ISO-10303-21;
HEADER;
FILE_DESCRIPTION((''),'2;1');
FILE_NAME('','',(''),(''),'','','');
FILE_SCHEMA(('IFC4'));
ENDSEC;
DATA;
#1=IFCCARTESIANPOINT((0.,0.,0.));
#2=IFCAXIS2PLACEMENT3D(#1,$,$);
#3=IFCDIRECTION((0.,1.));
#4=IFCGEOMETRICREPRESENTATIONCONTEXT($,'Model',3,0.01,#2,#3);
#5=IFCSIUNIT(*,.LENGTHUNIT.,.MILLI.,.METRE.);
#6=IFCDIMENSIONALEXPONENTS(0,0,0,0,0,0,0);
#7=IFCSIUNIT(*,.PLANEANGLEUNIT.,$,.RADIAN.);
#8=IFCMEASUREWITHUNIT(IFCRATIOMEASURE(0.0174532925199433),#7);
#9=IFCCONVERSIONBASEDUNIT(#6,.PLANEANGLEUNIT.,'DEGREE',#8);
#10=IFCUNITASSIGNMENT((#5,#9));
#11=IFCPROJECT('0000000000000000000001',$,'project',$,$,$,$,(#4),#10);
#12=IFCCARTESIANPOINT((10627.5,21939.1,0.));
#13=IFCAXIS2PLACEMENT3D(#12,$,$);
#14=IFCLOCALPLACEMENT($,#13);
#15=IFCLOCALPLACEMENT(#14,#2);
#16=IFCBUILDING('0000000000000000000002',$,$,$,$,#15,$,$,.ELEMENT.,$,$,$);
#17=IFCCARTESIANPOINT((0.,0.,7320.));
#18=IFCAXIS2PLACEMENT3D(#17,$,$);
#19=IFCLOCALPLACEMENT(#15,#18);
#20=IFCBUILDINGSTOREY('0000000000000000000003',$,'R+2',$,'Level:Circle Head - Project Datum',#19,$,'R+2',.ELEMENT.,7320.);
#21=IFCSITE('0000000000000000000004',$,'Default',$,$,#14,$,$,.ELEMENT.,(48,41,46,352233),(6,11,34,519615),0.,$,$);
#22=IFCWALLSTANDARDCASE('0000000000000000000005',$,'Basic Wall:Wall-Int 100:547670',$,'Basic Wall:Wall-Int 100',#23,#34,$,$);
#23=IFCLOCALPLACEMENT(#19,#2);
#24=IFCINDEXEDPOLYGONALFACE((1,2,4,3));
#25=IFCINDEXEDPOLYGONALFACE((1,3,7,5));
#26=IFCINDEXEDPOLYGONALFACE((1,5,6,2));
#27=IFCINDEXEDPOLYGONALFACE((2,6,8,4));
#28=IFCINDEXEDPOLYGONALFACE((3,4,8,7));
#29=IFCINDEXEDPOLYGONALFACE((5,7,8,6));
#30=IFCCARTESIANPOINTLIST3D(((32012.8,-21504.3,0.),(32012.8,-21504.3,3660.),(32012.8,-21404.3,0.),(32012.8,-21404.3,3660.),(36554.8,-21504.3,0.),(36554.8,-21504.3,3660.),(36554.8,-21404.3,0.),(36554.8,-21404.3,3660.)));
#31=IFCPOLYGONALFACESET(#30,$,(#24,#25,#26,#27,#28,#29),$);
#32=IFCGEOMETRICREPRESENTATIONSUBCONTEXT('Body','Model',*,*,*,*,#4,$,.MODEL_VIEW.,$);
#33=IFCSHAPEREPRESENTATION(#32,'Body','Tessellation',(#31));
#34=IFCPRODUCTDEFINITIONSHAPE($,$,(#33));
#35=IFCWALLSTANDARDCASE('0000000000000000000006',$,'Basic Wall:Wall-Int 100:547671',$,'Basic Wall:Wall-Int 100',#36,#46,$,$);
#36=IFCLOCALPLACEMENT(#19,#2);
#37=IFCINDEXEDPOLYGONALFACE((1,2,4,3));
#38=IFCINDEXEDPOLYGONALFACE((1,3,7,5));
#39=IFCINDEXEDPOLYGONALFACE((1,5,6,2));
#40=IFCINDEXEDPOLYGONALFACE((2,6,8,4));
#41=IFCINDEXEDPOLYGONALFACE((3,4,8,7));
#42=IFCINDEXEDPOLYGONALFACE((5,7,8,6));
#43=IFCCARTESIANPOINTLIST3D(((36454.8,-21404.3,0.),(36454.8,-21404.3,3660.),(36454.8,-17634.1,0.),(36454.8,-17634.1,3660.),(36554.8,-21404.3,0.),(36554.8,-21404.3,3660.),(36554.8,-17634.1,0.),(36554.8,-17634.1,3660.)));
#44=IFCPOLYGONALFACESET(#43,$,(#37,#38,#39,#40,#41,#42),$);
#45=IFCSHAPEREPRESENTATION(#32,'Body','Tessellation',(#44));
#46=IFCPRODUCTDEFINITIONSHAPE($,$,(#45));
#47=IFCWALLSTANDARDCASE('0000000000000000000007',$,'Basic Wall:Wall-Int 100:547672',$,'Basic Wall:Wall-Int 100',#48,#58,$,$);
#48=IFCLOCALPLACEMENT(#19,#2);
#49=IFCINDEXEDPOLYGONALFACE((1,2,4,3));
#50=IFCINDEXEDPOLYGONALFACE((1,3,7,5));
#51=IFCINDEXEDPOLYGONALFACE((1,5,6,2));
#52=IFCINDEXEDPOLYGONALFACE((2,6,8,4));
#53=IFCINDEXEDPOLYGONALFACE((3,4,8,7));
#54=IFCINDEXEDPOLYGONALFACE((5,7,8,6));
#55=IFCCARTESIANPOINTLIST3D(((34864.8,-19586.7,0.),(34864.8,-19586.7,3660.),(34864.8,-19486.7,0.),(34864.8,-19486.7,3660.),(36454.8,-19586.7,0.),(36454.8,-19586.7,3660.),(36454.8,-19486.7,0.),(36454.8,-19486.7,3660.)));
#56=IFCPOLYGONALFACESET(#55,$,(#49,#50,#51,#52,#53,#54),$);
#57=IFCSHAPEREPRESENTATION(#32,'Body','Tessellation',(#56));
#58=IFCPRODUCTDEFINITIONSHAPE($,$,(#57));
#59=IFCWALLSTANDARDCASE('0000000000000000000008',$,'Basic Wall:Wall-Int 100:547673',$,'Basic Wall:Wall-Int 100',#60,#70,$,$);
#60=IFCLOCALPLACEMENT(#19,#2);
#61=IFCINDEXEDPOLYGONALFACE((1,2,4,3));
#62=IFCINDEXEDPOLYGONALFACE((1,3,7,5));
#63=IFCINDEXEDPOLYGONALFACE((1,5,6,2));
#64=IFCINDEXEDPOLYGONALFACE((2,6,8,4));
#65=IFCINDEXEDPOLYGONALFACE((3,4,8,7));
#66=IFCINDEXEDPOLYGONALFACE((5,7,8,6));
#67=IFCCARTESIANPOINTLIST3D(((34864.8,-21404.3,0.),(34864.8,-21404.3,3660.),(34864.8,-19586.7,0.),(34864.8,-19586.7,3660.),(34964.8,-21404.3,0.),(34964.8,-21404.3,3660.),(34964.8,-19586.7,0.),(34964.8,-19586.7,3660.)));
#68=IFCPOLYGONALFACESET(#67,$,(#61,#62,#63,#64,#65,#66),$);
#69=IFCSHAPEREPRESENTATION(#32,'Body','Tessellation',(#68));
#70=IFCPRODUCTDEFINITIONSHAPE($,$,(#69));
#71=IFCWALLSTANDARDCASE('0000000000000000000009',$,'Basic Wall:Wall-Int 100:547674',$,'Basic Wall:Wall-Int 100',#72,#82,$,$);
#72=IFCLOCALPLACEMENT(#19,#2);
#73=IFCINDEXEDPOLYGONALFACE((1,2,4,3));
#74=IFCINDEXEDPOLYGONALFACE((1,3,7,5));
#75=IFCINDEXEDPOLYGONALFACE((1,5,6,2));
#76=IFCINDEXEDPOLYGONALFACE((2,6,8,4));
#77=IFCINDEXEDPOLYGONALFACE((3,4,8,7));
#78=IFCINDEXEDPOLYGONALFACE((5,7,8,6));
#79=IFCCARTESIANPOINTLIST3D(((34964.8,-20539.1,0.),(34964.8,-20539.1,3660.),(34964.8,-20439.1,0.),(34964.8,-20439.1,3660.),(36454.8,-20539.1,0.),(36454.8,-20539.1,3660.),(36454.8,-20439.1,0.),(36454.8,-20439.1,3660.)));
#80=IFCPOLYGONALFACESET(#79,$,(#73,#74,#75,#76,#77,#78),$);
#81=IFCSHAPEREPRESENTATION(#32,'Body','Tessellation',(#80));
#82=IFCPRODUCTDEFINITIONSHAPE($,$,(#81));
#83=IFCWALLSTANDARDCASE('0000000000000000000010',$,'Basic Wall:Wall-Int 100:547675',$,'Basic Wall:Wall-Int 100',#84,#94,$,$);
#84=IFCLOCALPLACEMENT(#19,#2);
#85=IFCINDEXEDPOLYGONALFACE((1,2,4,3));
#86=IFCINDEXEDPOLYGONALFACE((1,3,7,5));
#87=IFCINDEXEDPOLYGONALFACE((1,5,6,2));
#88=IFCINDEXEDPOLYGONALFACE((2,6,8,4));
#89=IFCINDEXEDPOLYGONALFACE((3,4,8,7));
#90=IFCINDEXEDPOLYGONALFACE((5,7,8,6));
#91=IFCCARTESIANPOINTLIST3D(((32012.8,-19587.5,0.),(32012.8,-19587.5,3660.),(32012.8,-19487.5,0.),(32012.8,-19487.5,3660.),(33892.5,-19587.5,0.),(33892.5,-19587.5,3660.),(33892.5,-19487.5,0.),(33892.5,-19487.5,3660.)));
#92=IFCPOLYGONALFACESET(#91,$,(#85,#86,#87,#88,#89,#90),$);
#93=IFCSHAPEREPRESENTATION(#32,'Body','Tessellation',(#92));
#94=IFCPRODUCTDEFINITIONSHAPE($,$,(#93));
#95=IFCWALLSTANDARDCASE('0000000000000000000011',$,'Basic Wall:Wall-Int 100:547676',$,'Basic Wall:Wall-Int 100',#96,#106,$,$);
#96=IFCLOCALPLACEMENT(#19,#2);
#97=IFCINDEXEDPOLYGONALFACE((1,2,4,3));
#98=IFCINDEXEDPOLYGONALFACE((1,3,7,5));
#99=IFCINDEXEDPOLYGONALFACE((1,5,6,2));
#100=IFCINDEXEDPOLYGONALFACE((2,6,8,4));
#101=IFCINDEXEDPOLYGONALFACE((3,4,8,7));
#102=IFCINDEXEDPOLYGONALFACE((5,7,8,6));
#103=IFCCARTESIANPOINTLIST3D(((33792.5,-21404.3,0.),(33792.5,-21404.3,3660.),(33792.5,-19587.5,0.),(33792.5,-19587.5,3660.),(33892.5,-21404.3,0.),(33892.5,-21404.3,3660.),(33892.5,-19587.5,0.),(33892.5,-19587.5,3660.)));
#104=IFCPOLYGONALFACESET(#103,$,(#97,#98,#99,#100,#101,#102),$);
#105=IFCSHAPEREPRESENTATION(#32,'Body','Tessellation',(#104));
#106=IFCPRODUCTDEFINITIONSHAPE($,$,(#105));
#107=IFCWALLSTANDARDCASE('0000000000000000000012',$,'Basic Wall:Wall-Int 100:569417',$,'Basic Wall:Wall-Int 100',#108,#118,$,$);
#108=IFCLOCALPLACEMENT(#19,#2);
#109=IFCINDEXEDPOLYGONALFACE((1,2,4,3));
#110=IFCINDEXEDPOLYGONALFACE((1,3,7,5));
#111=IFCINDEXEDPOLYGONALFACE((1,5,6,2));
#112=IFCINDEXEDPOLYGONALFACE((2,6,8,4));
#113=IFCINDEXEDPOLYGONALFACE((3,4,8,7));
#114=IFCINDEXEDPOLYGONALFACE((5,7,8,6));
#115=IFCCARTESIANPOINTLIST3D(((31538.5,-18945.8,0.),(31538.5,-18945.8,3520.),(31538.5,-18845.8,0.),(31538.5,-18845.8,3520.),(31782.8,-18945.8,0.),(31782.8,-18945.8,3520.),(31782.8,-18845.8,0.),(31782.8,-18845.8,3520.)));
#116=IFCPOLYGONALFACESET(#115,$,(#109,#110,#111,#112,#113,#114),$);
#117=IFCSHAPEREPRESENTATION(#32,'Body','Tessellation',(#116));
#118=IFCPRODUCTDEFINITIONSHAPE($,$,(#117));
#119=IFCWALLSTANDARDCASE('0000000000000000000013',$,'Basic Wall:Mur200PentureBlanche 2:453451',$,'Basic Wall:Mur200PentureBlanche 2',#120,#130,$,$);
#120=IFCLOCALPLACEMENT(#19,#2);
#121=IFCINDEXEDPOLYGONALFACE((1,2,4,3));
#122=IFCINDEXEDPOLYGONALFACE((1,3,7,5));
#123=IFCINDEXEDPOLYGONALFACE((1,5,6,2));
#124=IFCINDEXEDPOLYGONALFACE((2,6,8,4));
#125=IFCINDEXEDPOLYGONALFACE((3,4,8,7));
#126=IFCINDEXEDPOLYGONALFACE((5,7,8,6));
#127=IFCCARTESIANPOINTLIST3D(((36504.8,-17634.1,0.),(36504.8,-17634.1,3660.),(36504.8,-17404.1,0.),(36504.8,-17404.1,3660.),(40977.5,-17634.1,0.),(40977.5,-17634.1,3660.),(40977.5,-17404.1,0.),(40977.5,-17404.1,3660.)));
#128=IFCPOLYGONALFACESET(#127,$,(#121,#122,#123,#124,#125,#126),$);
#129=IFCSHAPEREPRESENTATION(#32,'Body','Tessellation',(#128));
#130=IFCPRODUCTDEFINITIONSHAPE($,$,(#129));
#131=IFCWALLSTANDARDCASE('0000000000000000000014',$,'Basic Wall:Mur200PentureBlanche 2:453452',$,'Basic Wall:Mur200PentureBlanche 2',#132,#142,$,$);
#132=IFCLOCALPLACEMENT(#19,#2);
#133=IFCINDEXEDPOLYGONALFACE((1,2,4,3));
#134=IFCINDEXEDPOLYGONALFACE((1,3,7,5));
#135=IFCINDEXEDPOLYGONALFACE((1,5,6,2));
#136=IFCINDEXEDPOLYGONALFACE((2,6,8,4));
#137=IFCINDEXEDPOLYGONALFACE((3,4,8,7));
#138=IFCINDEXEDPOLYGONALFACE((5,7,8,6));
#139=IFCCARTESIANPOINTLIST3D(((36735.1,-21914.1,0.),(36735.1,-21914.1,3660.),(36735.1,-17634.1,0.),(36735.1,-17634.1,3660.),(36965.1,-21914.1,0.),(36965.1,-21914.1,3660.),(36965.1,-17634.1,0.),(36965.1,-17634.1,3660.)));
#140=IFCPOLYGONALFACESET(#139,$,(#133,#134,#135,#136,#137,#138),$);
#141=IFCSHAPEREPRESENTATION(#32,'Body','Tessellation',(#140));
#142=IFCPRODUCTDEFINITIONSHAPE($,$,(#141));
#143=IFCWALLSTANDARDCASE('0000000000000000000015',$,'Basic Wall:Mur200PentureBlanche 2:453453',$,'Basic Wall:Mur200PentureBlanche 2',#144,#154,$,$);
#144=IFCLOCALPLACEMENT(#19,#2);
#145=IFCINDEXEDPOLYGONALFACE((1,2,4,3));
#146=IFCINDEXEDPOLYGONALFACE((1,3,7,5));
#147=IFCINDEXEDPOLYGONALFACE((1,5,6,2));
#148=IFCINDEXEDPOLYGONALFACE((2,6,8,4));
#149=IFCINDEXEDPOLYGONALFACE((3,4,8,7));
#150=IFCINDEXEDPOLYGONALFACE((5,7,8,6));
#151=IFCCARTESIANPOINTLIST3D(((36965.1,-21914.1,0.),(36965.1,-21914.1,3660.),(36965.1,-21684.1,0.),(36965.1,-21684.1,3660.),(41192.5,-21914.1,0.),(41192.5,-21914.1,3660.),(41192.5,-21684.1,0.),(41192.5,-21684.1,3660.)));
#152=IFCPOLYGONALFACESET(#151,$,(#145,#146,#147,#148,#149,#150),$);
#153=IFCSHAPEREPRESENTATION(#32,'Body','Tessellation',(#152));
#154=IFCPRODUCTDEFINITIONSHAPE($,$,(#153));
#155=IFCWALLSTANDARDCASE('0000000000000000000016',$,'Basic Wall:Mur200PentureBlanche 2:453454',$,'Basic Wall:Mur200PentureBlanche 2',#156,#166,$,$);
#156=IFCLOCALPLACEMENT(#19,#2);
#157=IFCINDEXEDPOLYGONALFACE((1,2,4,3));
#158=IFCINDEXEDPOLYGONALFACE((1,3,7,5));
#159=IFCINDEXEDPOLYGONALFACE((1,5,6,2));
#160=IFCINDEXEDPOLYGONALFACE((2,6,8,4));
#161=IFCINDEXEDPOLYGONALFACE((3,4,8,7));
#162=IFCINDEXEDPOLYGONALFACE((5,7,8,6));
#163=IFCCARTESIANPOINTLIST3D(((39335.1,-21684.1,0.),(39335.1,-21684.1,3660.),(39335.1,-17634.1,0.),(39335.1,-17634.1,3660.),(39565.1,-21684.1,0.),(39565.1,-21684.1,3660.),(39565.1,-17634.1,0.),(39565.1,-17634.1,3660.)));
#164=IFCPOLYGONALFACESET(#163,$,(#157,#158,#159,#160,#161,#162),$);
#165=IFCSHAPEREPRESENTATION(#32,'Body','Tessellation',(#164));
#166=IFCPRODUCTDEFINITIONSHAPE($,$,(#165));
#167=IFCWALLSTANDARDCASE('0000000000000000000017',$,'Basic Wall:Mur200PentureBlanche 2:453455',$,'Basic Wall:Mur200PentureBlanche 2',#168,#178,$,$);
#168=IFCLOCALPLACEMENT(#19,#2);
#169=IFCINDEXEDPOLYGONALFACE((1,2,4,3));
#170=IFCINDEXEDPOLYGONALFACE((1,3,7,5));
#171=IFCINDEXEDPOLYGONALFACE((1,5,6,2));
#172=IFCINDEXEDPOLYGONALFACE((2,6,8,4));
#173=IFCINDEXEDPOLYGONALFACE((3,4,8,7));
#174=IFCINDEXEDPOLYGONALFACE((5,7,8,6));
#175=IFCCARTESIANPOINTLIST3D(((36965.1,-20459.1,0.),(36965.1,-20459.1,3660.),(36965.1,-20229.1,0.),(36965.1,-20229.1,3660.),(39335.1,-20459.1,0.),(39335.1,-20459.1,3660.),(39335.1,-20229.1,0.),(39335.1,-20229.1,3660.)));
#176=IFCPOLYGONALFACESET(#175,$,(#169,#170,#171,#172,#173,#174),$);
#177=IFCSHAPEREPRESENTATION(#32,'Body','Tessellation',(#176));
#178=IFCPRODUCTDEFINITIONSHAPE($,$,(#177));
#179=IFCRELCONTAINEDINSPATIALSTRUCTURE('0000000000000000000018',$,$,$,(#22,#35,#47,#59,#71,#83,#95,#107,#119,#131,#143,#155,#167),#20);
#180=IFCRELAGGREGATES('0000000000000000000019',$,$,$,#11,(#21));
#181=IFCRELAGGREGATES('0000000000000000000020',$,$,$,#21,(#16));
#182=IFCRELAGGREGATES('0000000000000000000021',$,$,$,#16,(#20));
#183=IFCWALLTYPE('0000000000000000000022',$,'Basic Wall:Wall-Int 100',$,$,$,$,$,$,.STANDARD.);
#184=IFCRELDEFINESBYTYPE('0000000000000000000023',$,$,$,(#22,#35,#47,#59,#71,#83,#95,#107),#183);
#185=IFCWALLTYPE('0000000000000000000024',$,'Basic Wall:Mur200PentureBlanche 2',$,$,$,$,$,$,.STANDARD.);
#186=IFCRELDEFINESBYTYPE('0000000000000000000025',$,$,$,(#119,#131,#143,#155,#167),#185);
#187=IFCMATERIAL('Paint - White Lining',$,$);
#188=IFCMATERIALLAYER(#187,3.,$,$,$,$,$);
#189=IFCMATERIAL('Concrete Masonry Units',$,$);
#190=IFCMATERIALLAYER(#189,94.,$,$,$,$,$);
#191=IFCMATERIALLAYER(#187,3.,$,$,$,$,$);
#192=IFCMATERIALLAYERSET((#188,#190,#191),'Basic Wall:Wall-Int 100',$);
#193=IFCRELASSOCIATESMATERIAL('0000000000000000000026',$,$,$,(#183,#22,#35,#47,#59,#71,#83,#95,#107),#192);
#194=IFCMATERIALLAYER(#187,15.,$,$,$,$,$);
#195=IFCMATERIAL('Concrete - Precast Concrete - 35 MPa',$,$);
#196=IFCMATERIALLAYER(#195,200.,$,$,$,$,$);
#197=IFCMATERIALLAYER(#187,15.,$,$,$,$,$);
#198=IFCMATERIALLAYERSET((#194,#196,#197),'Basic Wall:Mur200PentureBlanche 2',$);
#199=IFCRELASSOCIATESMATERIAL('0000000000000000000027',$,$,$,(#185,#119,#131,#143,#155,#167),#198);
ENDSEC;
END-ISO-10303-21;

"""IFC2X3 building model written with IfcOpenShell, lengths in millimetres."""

from ifc_helpers import new_model, entity, si_unit, converted_unit, direction, frame, frame_2d, origin, place, context, subcontext, project, spatial, rectangle, extrude, material, layer, layer_set, layer_usage, type_object, element, save


model = new_model("IFC2X3")

# Units and contexts
model_context = context("Model", 3, precision=0.01, world=origin(), true_north=direction((0.0, 1.0)))
body_context = subcontext(model_context, "Body", "Model", "MODEL_VIEW")
ifc_project = project(units=[si_unit("LENGTHUNIT", "METRE", prefix="MILLI"), converted_unit("PLANEANGLEUNIT", "DEGREE", entity("IfcRatioMeasure", 0.0174532925199433), si_unit("PLANEANGLEUNIT", "RADIAN"), dimensions=[0, 0, 0, 0, 0, 0, 0])], contexts=[model_context])

# Site, building, storey
site_placement = place(None, frame((10627.5, 21939.1, 0.0)))
site = spatial("IfcSite", under=ifc_project, at=site_placement, Name="Default", CompositionType="ELEMENT", RefLatitude=(48, 41, 46, 352233), RefLongitude=(6, 11, 34, 519615), RefElevation=0.0)
building_placement = place(site_placement, origin())
building = spatial("IfcBuilding", under=site, at=building_placement, CompositionType="ELEMENT")
storey_placement = place(building_placement, frame((0.0, 0.0, 7320.0)))
storey = spatial("IfcBuildingStorey", under=building, at=storey_placement, Name="R+2", ObjectType="Level:Circle Head - Project Datum", LongName="R+2", CompositionType="ELEMENT", Elevation=7320.0)

# Walls
ifc_material_1 = material(Name="Paint - White Lining")
ifc_layer_1 = layer(ifc_material_1, 3.0)
ifc_material_2 = material(Name="Concrete Masonry Units")
ifc_layer_2 = layer(ifc_material_2, 94.0)
ifc_layer_3 = layer(ifc_material_1, 3.0)
ifc_layer_set_1 = layer_set([ifc_layer_1, ifc_layer_2, ifc_layer_3], Name="Basic Wall:Wall-Int 100")
ifc_layer_usage_1 = layer_usage(ifc_layer_set_1, "AXIS2", "NEGATIVE", 50.0)
wall_type_1 = type_object("IfcWallType", Name="Basic Wall:Wall-Int 100", PredefinedType="STANDARD", material=ifc_layer_set_1)
wall_1_placement = place(storey_placement, frame((36554.8, -21454.3, 0.0), z_axis=(0.0, 0.0, 1.0), x_axis=(-1.0, 0.0, 0.0)))
element("IfcWallStandardCase", 1, at=wall_1_placement, inside=storey, type_object=wall_type_1, material=ifc_layer_usage_1, Name="Basic Wall:Wall-Int 100:547670", ObjectType="Basic Wall:Wall-Int 100", context=body_context, shape_type="SweptSolid", body=[
    extrude(rectangle(XDim=4542.0, YDim=100.0, at=frame_2d((2271.0, 0.0), x_axis=(-1.0, 0.0))), origin(), (0.0, 0.0, 1.0), 3660.0),
])
ifc_layer_usage_2 = layer_usage(ifc_layer_set_1, "AXIS2", "POSITIVE", -50.0)
wall_2_placement = place(storey_placement, frame((36504.8, -21404.3, 0.0), z_axis=(0.0, 0.0, 1.0), x_axis=(0.0, 1.0, 0.0)))
element("IfcWallStandardCase", 2, at=wall_2_placement, inside=storey, type_object=wall_type_1, material=ifc_layer_usage_2, Name="Basic Wall:Wall-Int 100:547671", ObjectType="Basic Wall:Wall-Int 100", context=body_context, shape_type="SweptSolid", body=[
    extrude(rectangle(XDim=3770.2, YDim=100.0, at=frame_2d((1885.1, 0.0), x_axis=(-1.0, 0.0))), origin(), (0.0, 0.0, 1.0), 3660.0),
])
ifc_layer_usage_3 = layer_usage(ifc_layer_set_1, "AXIS2", "POSITIVE", -50.0)
wall_3_placement = place(storey_placement, frame((36454.8, -19536.7, 0.0), z_axis=(0.0, 0.0, 1.0), x_axis=(-1.0, 0.0, 0.0)))
element("IfcWallStandardCase", 3, at=wall_3_placement, inside=storey, type_object=wall_type_1, material=ifc_layer_usage_3, Name="Basic Wall:Wall-Int 100:547672", ObjectType="Basic Wall:Wall-Int 100", context=body_context, shape_type="SweptSolid", body=[
    extrude(rectangle(XDim=1590.0, YDim=100.0, at=frame_2d((795.0, 0.0), x_axis=(-1.0, 0.0))), origin(), (0.0, 0.0, 1.0), 3660.0),
])
ifc_layer_usage_4 = layer_usage(ifc_layer_set_1, "AXIS2", "POSITIVE", -50.0)
wall_4_placement = place(storey_placement, frame((34914.8, -19586.7, 0.0), z_axis=(0.0, 0.0, 1.0), x_axis=(0.0, -1.0, 0.0)))
element("IfcWallStandardCase", 4, at=wall_4_placement, inside=storey, type_object=wall_type_1, material=ifc_layer_usage_4, Name="Basic Wall:Wall-Int 100:547673", ObjectType="Basic Wall:Wall-Int 100", context=body_context, shape_type="SweptSolid", body=[
    extrude(rectangle(XDim=1817.6, YDim=100.0, at=frame_2d((908.8, 0.0), x_axis=(-1.0, 0.0))), origin(), (0.0, 0.0, 1.0), 3660.0),
])
ifc_layer_usage_5 = layer_usage(ifc_layer_set_1, "AXIS2", "POSITIVE", -50.0)
wall_5_placement = place(storey_placement, frame((34964.8, -20489.1, 0.0)))
element("IfcWallStandardCase", 5, at=wall_5_placement, inside=storey, type_object=wall_type_1, material=ifc_layer_usage_5, Name="Basic Wall:Wall-Int 100:547674", ObjectType="Basic Wall:Wall-Int 100", context=body_context, shape_type="SweptSolid", body=[
    extrude(rectangle(XDim=1490.0, YDim=100.0, at=frame_2d((745.0, 0.0), x_axis=(-1.0, 0.0))), origin(), (0.0, 0.0, 1.0), 3660.0),
])
ifc_layer_usage_6 = layer_usage(ifc_layer_set_1, "AXIS2", "NEGATIVE", 50.0)
wall_6_placement = place(storey_placement, frame((32012.8, -19537.5, 0.0)))
element("IfcWallStandardCase", 6, at=wall_6_placement, inside=storey, type_object=wall_type_1, material=ifc_layer_usage_6, Name="Basic Wall:Wall-Int 100:547675", ObjectType="Basic Wall:Wall-Int 100", context=body_context, shape_type="SweptSolid", body=[
    extrude(rectangle(XDim=1879.6, YDim=100.0, at=frame_2d((939.8, 0.0), x_axis=(-1.0, 0.0))), origin(), (0.0, 0.0, 1.0), 3660.0),
])
ifc_layer_usage_7 = layer_usage(ifc_layer_set_1, "AXIS2", "NEGATIVE", 50.0)
wall_7_placement = place(storey_placement, frame((33842.5, -19587.5, 0.0), z_axis=(0.0, 0.0, 1.0), x_axis=(0.0, -1.0, 0.0)))
element("IfcWallStandardCase", 7, at=wall_7_placement, inside=storey, type_object=wall_type_1, material=ifc_layer_usage_7, Name="Basic Wall:Wall-Int 100:547676", ObjectType="Basic Wall:Wall-Int 100", context=body_context, shape_type="SweptSolid", body=[
    extrude(rectangle(XDim=1816.8, YDim=100.0, at=frame_2d((908.4, 0.0), x_axis=(-1.0, 0.0))), origin(), (0.0, 0.0, 1.0), 3660.0),
])
ifc_layer_usage_8 = layer_usage(ifc_layer_set_1, "AXIS2", "POSITIVE", -50.0)
wall_8_placement = place(storey_placement, frame((31538.5, -18895.8, 0.0)))
element("IfcWallStandardCase", 8, at=wall_8_placement, inside=storey, type_object=wall_type_1, material=ifc_layer_usage_8, Name="Basic Wall:Wall-Int 100:569417", ObjectType="Basic Wall:Wall-Int 100", context=body_context, shape_type="SweptSolid", body=[
    extrude(rectangle(XDim=244.3, YDim=100.0, at=frame_2d((122.2, 0.0), x_axis=(-1.0, 0.0))), origin(), (0.0, 0.0, 1.0), 3520.0),
])
ifc_layer_4 = layer(ifc_material_1, 15.0)
ifc_material_3 = material(Name="Concrete - Precast Concrete - 35 MPa")
ifc_layer_5 = layer(ifc_material_3, 200.0)
ifc_layer_6 = layer(ifc_material_1, 15.0)
ifc_layer_set_2 = layer_set([ifc_layer_4, ifc_layer_5, ifc_layer_6], Name="Basic Wall:Mur200PentureBlanche 2")
ifc_layer_usage_9 = layer_usage(ifc_layer_set_2, "AXIS2", "POSITIVE", -115.0)
wall_type_2 = type_object("IfcWallType", Name="Basic Wall:Mur200PentureBlanche 2", PredefinedType="STANDARD", material=ifc_layer_set_2)
wall_9_placement = place(storey_placement, frame((40977.5, -17519.1, 0.0), z_axis=(0.0, 0.0, 1.0), x_axis=(-1.0, 0.0, 0.0)))
element("IfcWallStandardCase", 9, at=wall_9_placement, inside=storey, type_object=wall_type_2, material=ifc_layer_usage_9, Name="Basic Wall:Mur200PentureBlanche 2:453451", ObjectType="Basic Wall:Mur200PentureBlanche 2", context=body_context, shape_type="SweptSolid", body=[
    extrude(rectangle(XDim=4472.7, YDim=230.0, at=frame_2d((2236.3, 0.0), x_axis=(-1.0, 0.0))), origin(), (0.0, 0.0, 1.0), 3660.0),
])
ifc_layer_usage_10 = layer_usage(ifc_layer_set_2, "AXIS2", "POSITIVE", -115.0)
wall_10_placement = place(storey_placement, frame((36850.1, -17634.1, 0.0), z_axis=(0.0, 0.0, 1.0), x_axis=(0.0, -1.0, 0.0)))
element("IfcWallStandardCase", 10, at=wall_10_placement, inside=storey, type_object=wall_type_2, material=ifc_layer_usage_10, Name="Basic Wall:Mur200PentureBlanche 2:453452", ObjectType="Basic Wall:Mur200PentureBlanche 2", context=body_context, shape_type="SweptSolid", body=[
    extrude(rectangle(XDim=4280.0, YDim=230.0, at=frame_2d((2140.0, 0.0), x_axis=(-1.0, 0.0))), origin(), (0.0, 0.0, 1.0), 3660.0),
])
ifc_layer_usage_11 = layer_usage(ifc_layer_set_2, "AXIS2", "POSITIVE", -115.0)
wall_11_placement = place(storey_placement, frame((36965.1, -21799.1, 0.0)))
element("IfcWallStandardCase", 11, at=wall_11_placement, inside=storey, type_object=wall_type_2, material=ifc_layer_usage_11, Name="Basic Wall:Mur200PentureBlanche 2:453453", ObjectType="Basic Wall:Mur200PentureBlanche 2", context=body_context, shape_type="SweptSolid", body=[
    extrude(rectangle(XDim=4227.4, YDim=230.0, at=frame_2d((2113.7, 0.0), x_axis=(-1.0, 0.0))), origin(), (0.0, 0.0, 1.0), 3660.0),
])
ifc_layer_usage_12 = layer_usage(ifc_layer_set_2, "AXIS2", "NEGATIVE", 115.0)
wall_12_placement = place(storey_placement, frame((39450.1, -17634.1, 0.0), z_axis=(0.0, 0.0, 1.0), x_axis=(0.0, -1.0, 0.0)))
element("IfcWallStandardCase", 12, at=wall_12_placement, inside=storey, type_object=wall_type_2, material=ifc_layer_usage_12, Name="Basic Wall:Mur200PentureBlanche 2:453454", ObjectType="Basic Wall:Mur200PentureBlanche 2", context=body_context, shape_type="SweptSolid", body=[
    extrude(rectangle(XDim=4050.0, YDim=230.0, at=frame_2d((2025.0, 0.0), x_axis=(-1.0, 0.0))), origin(), (0.0, 0.0, 1.0), 3660.0),
])
ifc_layer_usage_13 = layer_usage(ifc_layer_set_2, "AXIS2", "POSITIVE", -115.0)
wall_13_placement = place(storey_placement, frame((39335.1, -20344.1, 0.0), z_axis=(0.0, 0.0, 1.0), x_axis=(-1.0, 0.0, 0.0)))
element("IfcWallStandardCase", 13, at=wall_13_placement, inside=storey, type_object=wall_type_2, material=ifc_layer_usage_13, Name="Basic Wall:Mur200PentureBlanche 2:453455", ObjectType="Basic Wall:Mur200PentureBlanche 2", context=body_context, shape_type="SweptSolid", body=[
    extrude(rectangle(XDim=2370.0, YDim=230.0, at=frame_2d((1185.0, 0.0), x_axis=(-1.0, 0.0))), origin(), (0.0, 0.0, 1.0), 3660.0),
])

save(model, "model.ifc")
